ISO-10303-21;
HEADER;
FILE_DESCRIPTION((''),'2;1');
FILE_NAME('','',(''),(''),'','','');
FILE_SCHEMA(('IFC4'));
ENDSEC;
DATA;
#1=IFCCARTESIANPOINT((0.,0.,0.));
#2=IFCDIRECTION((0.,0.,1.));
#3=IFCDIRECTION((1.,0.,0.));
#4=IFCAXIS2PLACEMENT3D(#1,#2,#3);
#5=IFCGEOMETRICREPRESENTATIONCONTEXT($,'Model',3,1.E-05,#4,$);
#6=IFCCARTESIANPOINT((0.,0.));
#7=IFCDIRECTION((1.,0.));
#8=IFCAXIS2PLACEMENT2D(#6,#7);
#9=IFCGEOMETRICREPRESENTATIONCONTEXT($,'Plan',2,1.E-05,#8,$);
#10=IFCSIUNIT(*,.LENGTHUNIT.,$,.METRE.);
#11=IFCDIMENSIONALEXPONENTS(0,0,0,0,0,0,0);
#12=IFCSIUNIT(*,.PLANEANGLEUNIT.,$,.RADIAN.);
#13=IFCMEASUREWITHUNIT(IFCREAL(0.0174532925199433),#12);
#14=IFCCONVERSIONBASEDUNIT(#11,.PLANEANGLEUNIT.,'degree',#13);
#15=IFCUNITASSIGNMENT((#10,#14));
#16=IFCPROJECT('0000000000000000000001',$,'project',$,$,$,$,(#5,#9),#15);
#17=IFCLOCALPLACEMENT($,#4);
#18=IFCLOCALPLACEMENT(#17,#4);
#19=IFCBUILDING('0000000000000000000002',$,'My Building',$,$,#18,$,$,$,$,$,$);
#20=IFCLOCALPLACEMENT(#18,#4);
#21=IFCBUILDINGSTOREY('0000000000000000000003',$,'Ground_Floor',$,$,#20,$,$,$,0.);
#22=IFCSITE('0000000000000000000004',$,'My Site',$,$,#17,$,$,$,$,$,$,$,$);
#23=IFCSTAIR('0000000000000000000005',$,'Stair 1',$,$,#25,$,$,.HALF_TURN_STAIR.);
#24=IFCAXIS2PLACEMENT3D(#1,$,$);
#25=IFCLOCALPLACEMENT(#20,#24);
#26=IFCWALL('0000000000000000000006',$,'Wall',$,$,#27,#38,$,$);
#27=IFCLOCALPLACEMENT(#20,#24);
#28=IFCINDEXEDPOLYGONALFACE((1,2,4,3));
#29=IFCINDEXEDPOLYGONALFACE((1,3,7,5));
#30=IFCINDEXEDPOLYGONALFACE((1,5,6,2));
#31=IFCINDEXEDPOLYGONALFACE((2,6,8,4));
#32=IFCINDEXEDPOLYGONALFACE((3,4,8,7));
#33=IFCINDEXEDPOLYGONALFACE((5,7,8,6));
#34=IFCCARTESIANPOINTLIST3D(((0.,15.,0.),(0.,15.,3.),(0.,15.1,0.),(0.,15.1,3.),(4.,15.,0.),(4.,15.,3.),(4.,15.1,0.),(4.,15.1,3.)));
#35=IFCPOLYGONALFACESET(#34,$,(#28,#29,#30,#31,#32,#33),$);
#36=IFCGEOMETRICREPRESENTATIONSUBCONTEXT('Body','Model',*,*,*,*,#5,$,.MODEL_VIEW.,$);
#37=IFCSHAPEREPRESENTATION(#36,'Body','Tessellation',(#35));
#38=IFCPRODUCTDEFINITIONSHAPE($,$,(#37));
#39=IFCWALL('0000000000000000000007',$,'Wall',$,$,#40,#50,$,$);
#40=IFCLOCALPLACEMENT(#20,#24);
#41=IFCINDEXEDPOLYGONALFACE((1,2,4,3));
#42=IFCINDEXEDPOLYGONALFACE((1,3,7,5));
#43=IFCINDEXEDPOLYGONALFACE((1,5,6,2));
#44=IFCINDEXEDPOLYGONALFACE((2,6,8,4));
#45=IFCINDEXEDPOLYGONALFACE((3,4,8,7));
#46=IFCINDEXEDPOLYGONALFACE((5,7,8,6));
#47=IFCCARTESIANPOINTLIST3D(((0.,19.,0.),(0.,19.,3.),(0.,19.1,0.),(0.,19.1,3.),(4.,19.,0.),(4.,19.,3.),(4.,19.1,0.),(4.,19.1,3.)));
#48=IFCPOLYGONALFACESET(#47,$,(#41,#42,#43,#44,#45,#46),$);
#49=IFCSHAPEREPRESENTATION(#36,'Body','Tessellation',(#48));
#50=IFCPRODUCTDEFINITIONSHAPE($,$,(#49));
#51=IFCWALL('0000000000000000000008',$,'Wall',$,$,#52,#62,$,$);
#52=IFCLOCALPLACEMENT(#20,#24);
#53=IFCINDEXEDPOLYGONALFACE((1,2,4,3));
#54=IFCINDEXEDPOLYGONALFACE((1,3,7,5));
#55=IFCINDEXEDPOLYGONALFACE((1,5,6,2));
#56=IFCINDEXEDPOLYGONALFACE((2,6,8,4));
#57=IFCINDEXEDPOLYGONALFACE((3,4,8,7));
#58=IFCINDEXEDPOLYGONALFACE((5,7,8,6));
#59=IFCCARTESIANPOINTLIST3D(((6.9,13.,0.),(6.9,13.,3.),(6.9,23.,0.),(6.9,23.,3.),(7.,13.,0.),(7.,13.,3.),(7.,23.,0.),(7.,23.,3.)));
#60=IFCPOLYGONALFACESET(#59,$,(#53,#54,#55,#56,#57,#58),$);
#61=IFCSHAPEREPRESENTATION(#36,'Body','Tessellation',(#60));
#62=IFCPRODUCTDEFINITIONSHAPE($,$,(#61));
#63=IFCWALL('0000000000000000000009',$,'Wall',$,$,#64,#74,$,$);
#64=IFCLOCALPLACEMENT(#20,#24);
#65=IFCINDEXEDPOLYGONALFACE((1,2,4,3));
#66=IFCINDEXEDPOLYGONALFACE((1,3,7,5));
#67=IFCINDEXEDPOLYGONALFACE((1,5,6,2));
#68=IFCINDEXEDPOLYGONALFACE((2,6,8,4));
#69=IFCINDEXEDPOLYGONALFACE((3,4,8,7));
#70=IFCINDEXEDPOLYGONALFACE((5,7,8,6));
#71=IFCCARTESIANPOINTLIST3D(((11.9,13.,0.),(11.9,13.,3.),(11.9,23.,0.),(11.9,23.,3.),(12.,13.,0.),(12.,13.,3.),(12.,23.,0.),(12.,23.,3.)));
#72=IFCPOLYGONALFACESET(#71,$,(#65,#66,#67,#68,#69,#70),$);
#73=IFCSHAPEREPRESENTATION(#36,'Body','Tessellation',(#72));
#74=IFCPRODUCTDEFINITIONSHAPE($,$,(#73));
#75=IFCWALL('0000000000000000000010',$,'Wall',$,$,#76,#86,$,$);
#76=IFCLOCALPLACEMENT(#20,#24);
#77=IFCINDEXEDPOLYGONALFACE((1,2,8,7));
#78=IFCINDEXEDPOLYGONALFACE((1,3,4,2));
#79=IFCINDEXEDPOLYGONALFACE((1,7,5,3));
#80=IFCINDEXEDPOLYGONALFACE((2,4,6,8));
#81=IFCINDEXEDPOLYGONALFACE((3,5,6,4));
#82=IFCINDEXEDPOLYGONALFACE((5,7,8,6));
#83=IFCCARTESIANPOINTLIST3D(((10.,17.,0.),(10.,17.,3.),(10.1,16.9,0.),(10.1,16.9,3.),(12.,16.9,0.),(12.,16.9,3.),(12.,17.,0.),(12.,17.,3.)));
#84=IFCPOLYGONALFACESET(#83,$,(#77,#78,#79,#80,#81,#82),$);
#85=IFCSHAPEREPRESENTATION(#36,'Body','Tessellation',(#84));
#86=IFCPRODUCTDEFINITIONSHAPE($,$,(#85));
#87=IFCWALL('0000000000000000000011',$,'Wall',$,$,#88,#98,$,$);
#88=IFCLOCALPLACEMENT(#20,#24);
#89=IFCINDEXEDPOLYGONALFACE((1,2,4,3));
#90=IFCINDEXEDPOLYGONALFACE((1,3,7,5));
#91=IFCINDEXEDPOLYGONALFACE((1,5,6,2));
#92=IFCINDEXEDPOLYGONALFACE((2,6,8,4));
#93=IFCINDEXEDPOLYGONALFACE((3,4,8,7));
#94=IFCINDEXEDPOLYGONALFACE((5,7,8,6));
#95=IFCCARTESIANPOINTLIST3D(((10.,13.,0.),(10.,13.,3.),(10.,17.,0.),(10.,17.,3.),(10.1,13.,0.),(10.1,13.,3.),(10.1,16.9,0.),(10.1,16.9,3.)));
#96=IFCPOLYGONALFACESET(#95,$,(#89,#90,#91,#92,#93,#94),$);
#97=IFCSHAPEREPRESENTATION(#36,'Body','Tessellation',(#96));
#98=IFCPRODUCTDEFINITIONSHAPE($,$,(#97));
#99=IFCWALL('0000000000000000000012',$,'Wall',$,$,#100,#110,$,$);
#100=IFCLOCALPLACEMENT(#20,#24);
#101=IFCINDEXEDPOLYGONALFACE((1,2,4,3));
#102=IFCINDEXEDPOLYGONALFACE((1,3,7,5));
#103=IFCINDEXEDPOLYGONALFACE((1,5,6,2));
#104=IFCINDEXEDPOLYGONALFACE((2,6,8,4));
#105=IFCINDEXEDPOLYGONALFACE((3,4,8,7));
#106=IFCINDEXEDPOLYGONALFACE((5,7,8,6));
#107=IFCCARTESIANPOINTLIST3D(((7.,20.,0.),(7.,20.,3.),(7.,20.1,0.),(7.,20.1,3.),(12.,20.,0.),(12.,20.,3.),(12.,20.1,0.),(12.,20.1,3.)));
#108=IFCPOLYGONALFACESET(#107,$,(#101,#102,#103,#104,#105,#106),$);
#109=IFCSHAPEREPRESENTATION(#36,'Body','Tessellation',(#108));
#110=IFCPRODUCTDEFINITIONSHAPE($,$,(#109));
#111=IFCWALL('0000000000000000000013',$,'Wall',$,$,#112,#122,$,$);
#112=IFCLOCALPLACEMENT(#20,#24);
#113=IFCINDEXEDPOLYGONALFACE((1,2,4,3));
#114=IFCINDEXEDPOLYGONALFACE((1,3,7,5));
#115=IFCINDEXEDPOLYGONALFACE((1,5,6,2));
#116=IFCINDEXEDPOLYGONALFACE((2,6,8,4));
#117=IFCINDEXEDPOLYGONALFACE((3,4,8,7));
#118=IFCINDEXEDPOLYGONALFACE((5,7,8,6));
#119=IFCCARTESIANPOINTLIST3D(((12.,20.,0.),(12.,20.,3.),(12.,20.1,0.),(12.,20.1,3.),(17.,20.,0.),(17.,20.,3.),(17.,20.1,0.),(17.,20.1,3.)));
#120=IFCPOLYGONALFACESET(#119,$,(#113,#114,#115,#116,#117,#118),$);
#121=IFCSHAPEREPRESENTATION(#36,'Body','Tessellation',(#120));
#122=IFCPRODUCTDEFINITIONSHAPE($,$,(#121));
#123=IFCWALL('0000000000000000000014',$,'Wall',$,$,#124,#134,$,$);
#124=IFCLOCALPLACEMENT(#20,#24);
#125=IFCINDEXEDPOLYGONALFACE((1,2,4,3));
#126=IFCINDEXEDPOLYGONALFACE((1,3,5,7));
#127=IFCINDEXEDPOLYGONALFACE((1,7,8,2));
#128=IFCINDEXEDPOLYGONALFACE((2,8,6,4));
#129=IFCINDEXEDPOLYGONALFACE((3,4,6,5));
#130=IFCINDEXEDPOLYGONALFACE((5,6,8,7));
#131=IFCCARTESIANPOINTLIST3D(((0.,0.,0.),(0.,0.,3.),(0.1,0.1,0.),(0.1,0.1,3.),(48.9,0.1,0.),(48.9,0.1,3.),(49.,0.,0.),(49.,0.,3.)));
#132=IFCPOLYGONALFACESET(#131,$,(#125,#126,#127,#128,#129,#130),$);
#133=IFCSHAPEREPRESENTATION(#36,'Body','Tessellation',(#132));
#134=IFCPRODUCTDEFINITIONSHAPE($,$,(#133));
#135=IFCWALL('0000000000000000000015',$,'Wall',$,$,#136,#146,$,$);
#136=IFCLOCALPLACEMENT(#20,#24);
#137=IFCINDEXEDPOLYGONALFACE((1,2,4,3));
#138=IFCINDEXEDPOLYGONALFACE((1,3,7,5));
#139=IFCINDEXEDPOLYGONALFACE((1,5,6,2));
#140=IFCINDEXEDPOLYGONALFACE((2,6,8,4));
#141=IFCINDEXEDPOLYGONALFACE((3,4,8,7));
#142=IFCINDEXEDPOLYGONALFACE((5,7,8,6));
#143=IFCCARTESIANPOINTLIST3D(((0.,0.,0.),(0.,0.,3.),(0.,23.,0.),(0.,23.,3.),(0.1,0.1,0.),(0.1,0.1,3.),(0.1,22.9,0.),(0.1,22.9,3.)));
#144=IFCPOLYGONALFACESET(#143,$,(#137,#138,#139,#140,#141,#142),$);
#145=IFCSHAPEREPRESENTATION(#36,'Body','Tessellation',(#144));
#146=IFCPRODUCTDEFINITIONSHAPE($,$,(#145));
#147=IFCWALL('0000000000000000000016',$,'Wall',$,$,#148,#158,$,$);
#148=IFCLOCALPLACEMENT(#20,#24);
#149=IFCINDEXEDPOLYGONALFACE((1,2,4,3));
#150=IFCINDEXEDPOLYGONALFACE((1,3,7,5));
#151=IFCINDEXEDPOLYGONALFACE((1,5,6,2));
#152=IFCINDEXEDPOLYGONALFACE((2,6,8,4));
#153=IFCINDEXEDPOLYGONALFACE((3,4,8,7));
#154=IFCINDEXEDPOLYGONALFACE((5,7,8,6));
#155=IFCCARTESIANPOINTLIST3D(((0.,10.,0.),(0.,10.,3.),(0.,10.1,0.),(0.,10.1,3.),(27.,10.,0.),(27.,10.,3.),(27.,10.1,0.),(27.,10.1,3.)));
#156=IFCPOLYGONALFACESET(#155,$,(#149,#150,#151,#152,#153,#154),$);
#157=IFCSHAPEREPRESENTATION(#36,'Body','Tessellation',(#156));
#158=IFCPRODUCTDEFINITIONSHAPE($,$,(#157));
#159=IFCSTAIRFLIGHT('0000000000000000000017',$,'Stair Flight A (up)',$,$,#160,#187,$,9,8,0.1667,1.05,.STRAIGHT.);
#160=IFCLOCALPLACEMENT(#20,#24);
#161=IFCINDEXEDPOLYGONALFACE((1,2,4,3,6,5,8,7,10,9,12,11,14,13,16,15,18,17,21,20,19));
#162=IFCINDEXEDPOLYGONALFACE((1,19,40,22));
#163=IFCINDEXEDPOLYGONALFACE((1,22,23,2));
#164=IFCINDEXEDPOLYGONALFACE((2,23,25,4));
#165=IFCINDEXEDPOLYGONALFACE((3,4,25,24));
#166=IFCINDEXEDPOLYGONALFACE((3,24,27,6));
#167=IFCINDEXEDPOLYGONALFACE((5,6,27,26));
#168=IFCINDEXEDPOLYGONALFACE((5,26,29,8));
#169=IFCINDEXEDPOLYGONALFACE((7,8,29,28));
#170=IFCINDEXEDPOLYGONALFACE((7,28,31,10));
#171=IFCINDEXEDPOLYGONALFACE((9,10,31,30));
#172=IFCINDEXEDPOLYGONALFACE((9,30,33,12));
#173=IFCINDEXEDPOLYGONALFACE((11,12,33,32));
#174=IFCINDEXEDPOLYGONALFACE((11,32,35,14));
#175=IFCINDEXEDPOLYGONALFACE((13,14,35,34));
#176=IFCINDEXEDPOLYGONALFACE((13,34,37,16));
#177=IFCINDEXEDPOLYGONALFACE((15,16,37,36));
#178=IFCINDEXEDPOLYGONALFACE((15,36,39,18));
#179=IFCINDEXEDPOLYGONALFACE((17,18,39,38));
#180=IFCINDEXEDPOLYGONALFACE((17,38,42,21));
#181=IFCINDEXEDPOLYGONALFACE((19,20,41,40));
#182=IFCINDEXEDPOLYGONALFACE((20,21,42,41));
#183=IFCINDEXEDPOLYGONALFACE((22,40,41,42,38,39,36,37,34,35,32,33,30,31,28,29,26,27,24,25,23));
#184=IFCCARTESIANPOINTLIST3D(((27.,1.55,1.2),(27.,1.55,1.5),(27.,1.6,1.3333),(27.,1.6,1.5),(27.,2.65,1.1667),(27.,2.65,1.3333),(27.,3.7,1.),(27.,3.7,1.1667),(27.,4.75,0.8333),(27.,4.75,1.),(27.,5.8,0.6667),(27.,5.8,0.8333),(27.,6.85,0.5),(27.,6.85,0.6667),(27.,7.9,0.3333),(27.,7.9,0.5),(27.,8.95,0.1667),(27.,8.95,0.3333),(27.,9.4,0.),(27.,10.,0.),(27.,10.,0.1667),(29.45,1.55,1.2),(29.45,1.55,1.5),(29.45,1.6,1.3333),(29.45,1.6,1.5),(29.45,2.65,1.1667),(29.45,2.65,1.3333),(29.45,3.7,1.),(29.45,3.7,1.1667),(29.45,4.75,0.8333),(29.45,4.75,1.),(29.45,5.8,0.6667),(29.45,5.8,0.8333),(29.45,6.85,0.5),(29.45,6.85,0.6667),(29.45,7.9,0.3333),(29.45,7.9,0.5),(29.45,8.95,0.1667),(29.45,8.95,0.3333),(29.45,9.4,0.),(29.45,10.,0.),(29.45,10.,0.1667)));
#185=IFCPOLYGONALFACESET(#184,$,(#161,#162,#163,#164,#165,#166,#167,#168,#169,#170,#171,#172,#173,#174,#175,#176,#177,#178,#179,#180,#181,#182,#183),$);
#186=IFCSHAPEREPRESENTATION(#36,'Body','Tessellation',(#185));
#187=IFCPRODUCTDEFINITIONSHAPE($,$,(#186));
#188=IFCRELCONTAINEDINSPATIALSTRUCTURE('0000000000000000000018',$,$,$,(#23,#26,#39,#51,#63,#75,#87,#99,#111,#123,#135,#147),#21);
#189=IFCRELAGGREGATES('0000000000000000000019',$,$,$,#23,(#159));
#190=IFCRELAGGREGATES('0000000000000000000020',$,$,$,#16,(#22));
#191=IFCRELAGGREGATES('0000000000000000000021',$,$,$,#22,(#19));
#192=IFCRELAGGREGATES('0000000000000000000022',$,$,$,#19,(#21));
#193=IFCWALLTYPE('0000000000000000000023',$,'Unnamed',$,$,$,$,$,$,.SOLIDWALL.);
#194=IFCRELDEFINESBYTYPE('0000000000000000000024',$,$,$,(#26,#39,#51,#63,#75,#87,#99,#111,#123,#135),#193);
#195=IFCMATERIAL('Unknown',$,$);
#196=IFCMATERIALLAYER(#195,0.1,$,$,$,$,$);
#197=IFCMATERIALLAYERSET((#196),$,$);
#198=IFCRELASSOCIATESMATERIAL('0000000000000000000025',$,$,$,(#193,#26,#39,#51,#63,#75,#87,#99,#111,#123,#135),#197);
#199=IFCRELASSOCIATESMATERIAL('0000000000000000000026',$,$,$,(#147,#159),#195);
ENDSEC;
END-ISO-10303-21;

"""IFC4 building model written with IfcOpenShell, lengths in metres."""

from ifc_helpers import new_model, entity, si_unit, converted_unit, frame, frame_2d, origin, origin_with_axes, origin_2d_with_axis, place, context, subcontext, project, spatial, polyline, line, indexed_curve, rectangle, outline, extrude, material, layer, layer_set, layer_usage, type_object, element, aggregate, save


model = new_model("IFC4")

# Units and contexts
model_context = context("Model", 3, precision=1e-05, world=origin_with_axes())
plan_context = context("Plan", 2, precision=1e-05, world=origin_2d_with_axis())
body_context = subcontext(model_context, "Body", "Model", "MODEL_VIEW")
ifc_project = project(units=[si_unit("LENGTHUNIT", "METRE"), converted_unit("PLANEANGLEUNIT", "degree", entity("IfcReal", 0.0174532925199433), si_unit("PLANEANGLEUNIT", "RADIAN"), dimensions=[0, 0, 0, 0, 0, 0, 0])], contexts=[model_context, plan_context])

# Site, building, storey
site_placement = place(None, origin_with_axes())
site = spatial("IfcSite", under=ifc_project, at=site_placement, Name="My Site")
building_placement = place(site_placement, origin_with_axes())
building = spatial("IfcBuilding", under=site, at=building_placement, Name="My Building")
storey_placement = place(building_placement, origin_with_axes())
storey = spatial("IfcBuildingStorey", under=building, at=storey_placement, Name="Ground_Floor", Elevation=0.0)

# Shared definitions
ifc_material = material(Name="Unknown")

# Stair
stair_placement = place(storey_placement, origin_with_axes())
stair = element("IfcStair", 1, at=stair_placement, inside=storey, Name="Stair 1", PredefinedType="HALF_TURN_STAIR")

# Walls
ifc_layer_1 = layer(ifc_material, 0.1)
ifc_layer_set_1 = layer_set([ifc_layer_1])
wall_type = type_object("IfcWallType", Name="Unnamed", PredefinedType="SOLIDWALL", material=ifc_layer_set_1)
ifc_layer_usage_1 = layer_usage(ifc_layer_set_1, "AXIS2", "POSITIVE", 0.0)
wall_1_placement = place(storey_placement, frame((0.0, 15.0, 0.0), z_axis=(0.0, 0.0, 1.0), x_axis=(1.0, 0.0, 0.0)))
element("IfcWall", 2, at=wall_1_placement, inside=storey, type_object=wall_type, material=ifc_layer_usage_1, Name="Wall", context=body_context, shape_type="SweptSolid", body=[
    extrude(outline(indexed_curve([(0.0, 0.0), (0.0, 0.1), (4.0, 0.1), (4.0, 0.0)], segments=[line(1, 2, 3, 4, 1)])), origin_with_axes(), (0.0, 0.0, 1.0), 3.0),
])
ifc_layer_usage_2 = layer_usage(ifc_layer_set_1, "AXIS2", "POSITIVE", 0.0)
wall_2_placement = place(storey_placement, frame((0.0, 19.0, 0.0), z_axis=(0.0, 0.0, 1.0), x_axis=(1.0, 0.0, 0.0)))
element("IfcWall", 3, at=wall_2_placement, inside=storey, type_object=wall_type, material=ifc_layer_usage_2, Name="Wall", context=body_context, shape_type="SweptSolid", body=[
    extrude(outline(indexed_curve([(0.0, 0.0), (0.0, 0.1), (4.0, 0.1), (4.0, 0.0)], segments=[line(1, 2, 3, 4, 1)])), origin_with_axes(), (0.0, 0.0, 1.0), 3.0),
])
ifc_layer_usage_3 = layer_usage(ifc_layer_set_1, "AXIS2", "POSITIVE", 0.0)
wall_3_placement = place(storey_placement, frame((7.0, 13.0, 0.0), z_axis=(0.0, 0.0, 1.0), x_axis=(0.0, 1.0, 0.0)))
element("IfcWall", 4, at=wall_3_placement, inside=storey, type_object=wall_type, material=ifc_layer_usage_3, Name="Wall", context=body_context, shape_type="SweptSolid", body=[
    extrude(outline(indexed_curve([(0.0, 0.0), (0.0, 0.1), (10.0, 0.1), (10.0, 0.0)], segments=[line(1, 2, 3, 4, 1)])), origin_with_axes(), (0.0, 0.0, 1.0), 3.0),
])
ifc_layer_usage_4 = layer_usage(ifc_layer_set_1, "AXIS2", "POSITIVE", 0.0)
wall_4_placement = place(storey_placement, frame((12.0, 13.0, 0.0), z_axis=(0.0, 0.0, 1.0), x_axis=(0.0, 1.0, 0.0)))
element("IfcWall", 5, at=wall_4_placement, inside=storey, type_object=wall_type, material=ifc_layer_usage_4, Name="Wall", context=body_context, shape_type="SweptSolid", body=[
    extrude(outline(indexed_curve([(0.0, 0.0), (0.0, 0.1), (10.0, 0.1), (10.0, 0.0)], segments=[line(1, 2, 3, 4, 1)])), origin_with_axes(), (0.0, 0.0, 1.0), 3.0),
])
ifc_layer_usage_5 = layer_usage(ifc_layer_set_1, "AXIS2", "POSITIVE", 0.0)
wall_5_placement = place(storey_placement, frame((12.0, 17.0, 0.0), z_axis=(0.0, 0.0, 1.0), x_axis=(-1.0, 0.0, 0.0)))
element("IfcWall", 6, at=wall_5_placement, inside=storey, type_object=wall_type, material=ifc_layer_usage_5, Name="Wall", context=body_context, shape_type="SweptSolid", body=[
    extrude(outline(indexed_curve([(0.0, 0.0), (0.0, 0.1), (1.9, 0.1), (2.0, 0.0)], segments=[line(1, 2, 3, 4, 1)])), origin_with_axes(), (0.0, 0.0, 1.0), 3.0),
])
ifc_layer_usage_6 = layer_usage(ifc_layer_set_1, "AXIS2", "POSITIVE", 0.0)
wall_6_placement = place(storey_placement, frame((10.0, 17.0, 0.0), z_axis=(0.0, 0.0, 1.0), x_axis=(0.0, -1.0, 0.0)))
element("IfcWall", 7, at=wall_6_placement, inside=storey, type_object=wall_type, material=ifc_layer_usage_6, Name="Wall", context=body_context, shape_type="SweptSolid", body=[
    extrude(outline(indexed_curve([(0.0, 0.0), (0.1, 0.1), (4.0, 0.1), (4.0, 0.0)], segments=[line(1, 2, 3, 4, 1)])), origin_with_axes(), (0.0, 0.0, 1.0), 3.0),
])
ifc_layer_usage_7 = layer_usage(ifc_layer_set_1, "AXIS2", "POSITIVE", 0.0)
wall_7_placement = place(storey_placement, frame((7.0, 20.0, 0.0), z_axis=(0.0, 0.0, 1.0), x_axis=(1.0, 0.0, 0.0)))
element("IfcWall", 8, at=wall_7_placement, inside=storey, type_object=wall_type, material=ifc_layer_usage_7, Name="Wall", context=body_context, shape_type="SweptSolid", body=[
    extrude(outline(indexed_curve([(0.0, 0.0), (0.0, 0.1), (5.0, 0.1), (5.0, 0.0)], segments=[line(1, 2, 3, 4, 1)])), origin_with_axes(), (0.0, 0.0, 1.0), 3.0),
])
ifc_layer_usage_8 = layer_usage(ifc_layer_set_1, "AXIS2", "POSITIVE", 0.0)
wall_8_placement = place(storey_placement, frame((12.0, 20.0, 0.0), z_axis=(0.0, 0.0, 1.0), x_axis=(1.0, 0.0, 0.0)))
element("IfcWall", 9, at=wall_8_placement, inside=storey, type_object=wall_type, material=ifc_layer_usage_8, Name="Wall", context=body_context, shape_type="SweptSolid", body=[
    extrude(outline(indexed_curve([(0.0, 0.0), (0.0, 0.1), (5.0, 0.1), (5.0, 0.0)], segments=[line(1, 2, 3, 4, 1)])), origin_with_axes(), (0.0, 0.0, 1.0), 3.0),
])
ifc_layer_usage_9 = layer_usage(ifc_layer_set_1, "AXIS2", "POSITIVE", 0.0)
wall_9_placement = place(storey_placement, frame((0.0, 0.0, 0.0), z_axis=(0.0, 0.0, 1.0), x_axis=(1.0, 0.0, 0.0)))
element("IfcWall", 10, at=wall_9_placement, inside=storey, type_object=wall_type, material=ifc_layer_usage_9, Name="Wall", context=body_context, shape_type="SweptSolid", body=[
    extrude(outline(indexed_curve([(0.0, 0.0), (0.1, 0.1), (48.9, 0.1), (49.0, 0.0)], segments=[line(1, 2, 3, 4, 1)])), origin_with_axes(), (0.0, 0.0, 1.0), 3.0),
])
ifc_layer_usage_10 = layer_usage(ifc_layer_set_1, "AXIS2", "POSITIVE", 0.0)
wall_10_placement = place(storey_placement, frame((0.0, 23.0, 0.0), z_axis=(0.0, 0.0, 1.0), x_axis=(0.0, -1.0, 0.0)))
element("IfcWall", 11, at=wall_10_placement, inside=storey, type_object=wall_type, material=ifc_layer_usage_10, Name="Wall", context=body_context, shape_type="SweptSolid", body=[
    extrude(outline(indexed_curve([(0.0, 0.0), (0.1, 0.1), (22.9, 0.1), (23.0, 0.0)], segments=[line(1, 2, 3, 4, 1)])), origin_with_axes(), (0.0, 0.0, 1.0), 3.0),
])
wall_11_placement = place(storey_placement, origin_with_axes())
element("IfcWall", 12, at=wall_11_placement, inside=storey, material=ifc_material, Name="Wall", context=body_context, shape_type="SweptSolid", body=[
    extrude(rectangle(XDim=27.0, YDim=0.1, at=frame_2d((13.5, 10.05))), origin(), (0.0, 0.0, 1.0), 3.0),
])

# Stair flight
stair_flight_1_placement = place(stair_placement, origin_with_axes())
stair_flight_1 = element("IfcStairFlight", 13, at=stair_flight_1_placement, material=ifc_material, Name="Stair Flight A (up)", NumberOfRisers=9, NumberOfTreads=8, PredefinedType="STRAIGHT", RiserHeight=0.1667, TreadLength=1.05, context=body_context, shape_type="SweptSolid", body=[
    extrude(outline(polyline([(10.0, 0.0), (10.0, 0.1667), (8.95, 0.1667), (8.95, 0.3333), (7.9, 0.3333), (7.9, 0.3333), (7.9, 0.5), (6.85, 0.5), (6.85, 0.5), (6.85, 0.6667), (5.8, 0.6667), (5.8, 0.8333), (4.75, 0.8333), (4.75, 1.0), (3.7, 1.0), (3.7, 1.0), (3.7, 1.1667), (2.65, 1.1667), (2.65, 1.3333), (1.6, 1.3333), (1.6, 1.3333), (1.6, 1.5), (1.55, 1.5), (1.55, 1.2), (9.4, 0.0), (10.0, 0.0)])), frame((27.0, 0.0, 0.0), z_axis=(1.0, 0.0, 0.0), x_axis=(0.0, 1.0, 0.0)), (0.0, 0.0, 1.0), 2.45),
])
aggregate(stair, [stair_flight_1])

save(model, "model.ifc")
